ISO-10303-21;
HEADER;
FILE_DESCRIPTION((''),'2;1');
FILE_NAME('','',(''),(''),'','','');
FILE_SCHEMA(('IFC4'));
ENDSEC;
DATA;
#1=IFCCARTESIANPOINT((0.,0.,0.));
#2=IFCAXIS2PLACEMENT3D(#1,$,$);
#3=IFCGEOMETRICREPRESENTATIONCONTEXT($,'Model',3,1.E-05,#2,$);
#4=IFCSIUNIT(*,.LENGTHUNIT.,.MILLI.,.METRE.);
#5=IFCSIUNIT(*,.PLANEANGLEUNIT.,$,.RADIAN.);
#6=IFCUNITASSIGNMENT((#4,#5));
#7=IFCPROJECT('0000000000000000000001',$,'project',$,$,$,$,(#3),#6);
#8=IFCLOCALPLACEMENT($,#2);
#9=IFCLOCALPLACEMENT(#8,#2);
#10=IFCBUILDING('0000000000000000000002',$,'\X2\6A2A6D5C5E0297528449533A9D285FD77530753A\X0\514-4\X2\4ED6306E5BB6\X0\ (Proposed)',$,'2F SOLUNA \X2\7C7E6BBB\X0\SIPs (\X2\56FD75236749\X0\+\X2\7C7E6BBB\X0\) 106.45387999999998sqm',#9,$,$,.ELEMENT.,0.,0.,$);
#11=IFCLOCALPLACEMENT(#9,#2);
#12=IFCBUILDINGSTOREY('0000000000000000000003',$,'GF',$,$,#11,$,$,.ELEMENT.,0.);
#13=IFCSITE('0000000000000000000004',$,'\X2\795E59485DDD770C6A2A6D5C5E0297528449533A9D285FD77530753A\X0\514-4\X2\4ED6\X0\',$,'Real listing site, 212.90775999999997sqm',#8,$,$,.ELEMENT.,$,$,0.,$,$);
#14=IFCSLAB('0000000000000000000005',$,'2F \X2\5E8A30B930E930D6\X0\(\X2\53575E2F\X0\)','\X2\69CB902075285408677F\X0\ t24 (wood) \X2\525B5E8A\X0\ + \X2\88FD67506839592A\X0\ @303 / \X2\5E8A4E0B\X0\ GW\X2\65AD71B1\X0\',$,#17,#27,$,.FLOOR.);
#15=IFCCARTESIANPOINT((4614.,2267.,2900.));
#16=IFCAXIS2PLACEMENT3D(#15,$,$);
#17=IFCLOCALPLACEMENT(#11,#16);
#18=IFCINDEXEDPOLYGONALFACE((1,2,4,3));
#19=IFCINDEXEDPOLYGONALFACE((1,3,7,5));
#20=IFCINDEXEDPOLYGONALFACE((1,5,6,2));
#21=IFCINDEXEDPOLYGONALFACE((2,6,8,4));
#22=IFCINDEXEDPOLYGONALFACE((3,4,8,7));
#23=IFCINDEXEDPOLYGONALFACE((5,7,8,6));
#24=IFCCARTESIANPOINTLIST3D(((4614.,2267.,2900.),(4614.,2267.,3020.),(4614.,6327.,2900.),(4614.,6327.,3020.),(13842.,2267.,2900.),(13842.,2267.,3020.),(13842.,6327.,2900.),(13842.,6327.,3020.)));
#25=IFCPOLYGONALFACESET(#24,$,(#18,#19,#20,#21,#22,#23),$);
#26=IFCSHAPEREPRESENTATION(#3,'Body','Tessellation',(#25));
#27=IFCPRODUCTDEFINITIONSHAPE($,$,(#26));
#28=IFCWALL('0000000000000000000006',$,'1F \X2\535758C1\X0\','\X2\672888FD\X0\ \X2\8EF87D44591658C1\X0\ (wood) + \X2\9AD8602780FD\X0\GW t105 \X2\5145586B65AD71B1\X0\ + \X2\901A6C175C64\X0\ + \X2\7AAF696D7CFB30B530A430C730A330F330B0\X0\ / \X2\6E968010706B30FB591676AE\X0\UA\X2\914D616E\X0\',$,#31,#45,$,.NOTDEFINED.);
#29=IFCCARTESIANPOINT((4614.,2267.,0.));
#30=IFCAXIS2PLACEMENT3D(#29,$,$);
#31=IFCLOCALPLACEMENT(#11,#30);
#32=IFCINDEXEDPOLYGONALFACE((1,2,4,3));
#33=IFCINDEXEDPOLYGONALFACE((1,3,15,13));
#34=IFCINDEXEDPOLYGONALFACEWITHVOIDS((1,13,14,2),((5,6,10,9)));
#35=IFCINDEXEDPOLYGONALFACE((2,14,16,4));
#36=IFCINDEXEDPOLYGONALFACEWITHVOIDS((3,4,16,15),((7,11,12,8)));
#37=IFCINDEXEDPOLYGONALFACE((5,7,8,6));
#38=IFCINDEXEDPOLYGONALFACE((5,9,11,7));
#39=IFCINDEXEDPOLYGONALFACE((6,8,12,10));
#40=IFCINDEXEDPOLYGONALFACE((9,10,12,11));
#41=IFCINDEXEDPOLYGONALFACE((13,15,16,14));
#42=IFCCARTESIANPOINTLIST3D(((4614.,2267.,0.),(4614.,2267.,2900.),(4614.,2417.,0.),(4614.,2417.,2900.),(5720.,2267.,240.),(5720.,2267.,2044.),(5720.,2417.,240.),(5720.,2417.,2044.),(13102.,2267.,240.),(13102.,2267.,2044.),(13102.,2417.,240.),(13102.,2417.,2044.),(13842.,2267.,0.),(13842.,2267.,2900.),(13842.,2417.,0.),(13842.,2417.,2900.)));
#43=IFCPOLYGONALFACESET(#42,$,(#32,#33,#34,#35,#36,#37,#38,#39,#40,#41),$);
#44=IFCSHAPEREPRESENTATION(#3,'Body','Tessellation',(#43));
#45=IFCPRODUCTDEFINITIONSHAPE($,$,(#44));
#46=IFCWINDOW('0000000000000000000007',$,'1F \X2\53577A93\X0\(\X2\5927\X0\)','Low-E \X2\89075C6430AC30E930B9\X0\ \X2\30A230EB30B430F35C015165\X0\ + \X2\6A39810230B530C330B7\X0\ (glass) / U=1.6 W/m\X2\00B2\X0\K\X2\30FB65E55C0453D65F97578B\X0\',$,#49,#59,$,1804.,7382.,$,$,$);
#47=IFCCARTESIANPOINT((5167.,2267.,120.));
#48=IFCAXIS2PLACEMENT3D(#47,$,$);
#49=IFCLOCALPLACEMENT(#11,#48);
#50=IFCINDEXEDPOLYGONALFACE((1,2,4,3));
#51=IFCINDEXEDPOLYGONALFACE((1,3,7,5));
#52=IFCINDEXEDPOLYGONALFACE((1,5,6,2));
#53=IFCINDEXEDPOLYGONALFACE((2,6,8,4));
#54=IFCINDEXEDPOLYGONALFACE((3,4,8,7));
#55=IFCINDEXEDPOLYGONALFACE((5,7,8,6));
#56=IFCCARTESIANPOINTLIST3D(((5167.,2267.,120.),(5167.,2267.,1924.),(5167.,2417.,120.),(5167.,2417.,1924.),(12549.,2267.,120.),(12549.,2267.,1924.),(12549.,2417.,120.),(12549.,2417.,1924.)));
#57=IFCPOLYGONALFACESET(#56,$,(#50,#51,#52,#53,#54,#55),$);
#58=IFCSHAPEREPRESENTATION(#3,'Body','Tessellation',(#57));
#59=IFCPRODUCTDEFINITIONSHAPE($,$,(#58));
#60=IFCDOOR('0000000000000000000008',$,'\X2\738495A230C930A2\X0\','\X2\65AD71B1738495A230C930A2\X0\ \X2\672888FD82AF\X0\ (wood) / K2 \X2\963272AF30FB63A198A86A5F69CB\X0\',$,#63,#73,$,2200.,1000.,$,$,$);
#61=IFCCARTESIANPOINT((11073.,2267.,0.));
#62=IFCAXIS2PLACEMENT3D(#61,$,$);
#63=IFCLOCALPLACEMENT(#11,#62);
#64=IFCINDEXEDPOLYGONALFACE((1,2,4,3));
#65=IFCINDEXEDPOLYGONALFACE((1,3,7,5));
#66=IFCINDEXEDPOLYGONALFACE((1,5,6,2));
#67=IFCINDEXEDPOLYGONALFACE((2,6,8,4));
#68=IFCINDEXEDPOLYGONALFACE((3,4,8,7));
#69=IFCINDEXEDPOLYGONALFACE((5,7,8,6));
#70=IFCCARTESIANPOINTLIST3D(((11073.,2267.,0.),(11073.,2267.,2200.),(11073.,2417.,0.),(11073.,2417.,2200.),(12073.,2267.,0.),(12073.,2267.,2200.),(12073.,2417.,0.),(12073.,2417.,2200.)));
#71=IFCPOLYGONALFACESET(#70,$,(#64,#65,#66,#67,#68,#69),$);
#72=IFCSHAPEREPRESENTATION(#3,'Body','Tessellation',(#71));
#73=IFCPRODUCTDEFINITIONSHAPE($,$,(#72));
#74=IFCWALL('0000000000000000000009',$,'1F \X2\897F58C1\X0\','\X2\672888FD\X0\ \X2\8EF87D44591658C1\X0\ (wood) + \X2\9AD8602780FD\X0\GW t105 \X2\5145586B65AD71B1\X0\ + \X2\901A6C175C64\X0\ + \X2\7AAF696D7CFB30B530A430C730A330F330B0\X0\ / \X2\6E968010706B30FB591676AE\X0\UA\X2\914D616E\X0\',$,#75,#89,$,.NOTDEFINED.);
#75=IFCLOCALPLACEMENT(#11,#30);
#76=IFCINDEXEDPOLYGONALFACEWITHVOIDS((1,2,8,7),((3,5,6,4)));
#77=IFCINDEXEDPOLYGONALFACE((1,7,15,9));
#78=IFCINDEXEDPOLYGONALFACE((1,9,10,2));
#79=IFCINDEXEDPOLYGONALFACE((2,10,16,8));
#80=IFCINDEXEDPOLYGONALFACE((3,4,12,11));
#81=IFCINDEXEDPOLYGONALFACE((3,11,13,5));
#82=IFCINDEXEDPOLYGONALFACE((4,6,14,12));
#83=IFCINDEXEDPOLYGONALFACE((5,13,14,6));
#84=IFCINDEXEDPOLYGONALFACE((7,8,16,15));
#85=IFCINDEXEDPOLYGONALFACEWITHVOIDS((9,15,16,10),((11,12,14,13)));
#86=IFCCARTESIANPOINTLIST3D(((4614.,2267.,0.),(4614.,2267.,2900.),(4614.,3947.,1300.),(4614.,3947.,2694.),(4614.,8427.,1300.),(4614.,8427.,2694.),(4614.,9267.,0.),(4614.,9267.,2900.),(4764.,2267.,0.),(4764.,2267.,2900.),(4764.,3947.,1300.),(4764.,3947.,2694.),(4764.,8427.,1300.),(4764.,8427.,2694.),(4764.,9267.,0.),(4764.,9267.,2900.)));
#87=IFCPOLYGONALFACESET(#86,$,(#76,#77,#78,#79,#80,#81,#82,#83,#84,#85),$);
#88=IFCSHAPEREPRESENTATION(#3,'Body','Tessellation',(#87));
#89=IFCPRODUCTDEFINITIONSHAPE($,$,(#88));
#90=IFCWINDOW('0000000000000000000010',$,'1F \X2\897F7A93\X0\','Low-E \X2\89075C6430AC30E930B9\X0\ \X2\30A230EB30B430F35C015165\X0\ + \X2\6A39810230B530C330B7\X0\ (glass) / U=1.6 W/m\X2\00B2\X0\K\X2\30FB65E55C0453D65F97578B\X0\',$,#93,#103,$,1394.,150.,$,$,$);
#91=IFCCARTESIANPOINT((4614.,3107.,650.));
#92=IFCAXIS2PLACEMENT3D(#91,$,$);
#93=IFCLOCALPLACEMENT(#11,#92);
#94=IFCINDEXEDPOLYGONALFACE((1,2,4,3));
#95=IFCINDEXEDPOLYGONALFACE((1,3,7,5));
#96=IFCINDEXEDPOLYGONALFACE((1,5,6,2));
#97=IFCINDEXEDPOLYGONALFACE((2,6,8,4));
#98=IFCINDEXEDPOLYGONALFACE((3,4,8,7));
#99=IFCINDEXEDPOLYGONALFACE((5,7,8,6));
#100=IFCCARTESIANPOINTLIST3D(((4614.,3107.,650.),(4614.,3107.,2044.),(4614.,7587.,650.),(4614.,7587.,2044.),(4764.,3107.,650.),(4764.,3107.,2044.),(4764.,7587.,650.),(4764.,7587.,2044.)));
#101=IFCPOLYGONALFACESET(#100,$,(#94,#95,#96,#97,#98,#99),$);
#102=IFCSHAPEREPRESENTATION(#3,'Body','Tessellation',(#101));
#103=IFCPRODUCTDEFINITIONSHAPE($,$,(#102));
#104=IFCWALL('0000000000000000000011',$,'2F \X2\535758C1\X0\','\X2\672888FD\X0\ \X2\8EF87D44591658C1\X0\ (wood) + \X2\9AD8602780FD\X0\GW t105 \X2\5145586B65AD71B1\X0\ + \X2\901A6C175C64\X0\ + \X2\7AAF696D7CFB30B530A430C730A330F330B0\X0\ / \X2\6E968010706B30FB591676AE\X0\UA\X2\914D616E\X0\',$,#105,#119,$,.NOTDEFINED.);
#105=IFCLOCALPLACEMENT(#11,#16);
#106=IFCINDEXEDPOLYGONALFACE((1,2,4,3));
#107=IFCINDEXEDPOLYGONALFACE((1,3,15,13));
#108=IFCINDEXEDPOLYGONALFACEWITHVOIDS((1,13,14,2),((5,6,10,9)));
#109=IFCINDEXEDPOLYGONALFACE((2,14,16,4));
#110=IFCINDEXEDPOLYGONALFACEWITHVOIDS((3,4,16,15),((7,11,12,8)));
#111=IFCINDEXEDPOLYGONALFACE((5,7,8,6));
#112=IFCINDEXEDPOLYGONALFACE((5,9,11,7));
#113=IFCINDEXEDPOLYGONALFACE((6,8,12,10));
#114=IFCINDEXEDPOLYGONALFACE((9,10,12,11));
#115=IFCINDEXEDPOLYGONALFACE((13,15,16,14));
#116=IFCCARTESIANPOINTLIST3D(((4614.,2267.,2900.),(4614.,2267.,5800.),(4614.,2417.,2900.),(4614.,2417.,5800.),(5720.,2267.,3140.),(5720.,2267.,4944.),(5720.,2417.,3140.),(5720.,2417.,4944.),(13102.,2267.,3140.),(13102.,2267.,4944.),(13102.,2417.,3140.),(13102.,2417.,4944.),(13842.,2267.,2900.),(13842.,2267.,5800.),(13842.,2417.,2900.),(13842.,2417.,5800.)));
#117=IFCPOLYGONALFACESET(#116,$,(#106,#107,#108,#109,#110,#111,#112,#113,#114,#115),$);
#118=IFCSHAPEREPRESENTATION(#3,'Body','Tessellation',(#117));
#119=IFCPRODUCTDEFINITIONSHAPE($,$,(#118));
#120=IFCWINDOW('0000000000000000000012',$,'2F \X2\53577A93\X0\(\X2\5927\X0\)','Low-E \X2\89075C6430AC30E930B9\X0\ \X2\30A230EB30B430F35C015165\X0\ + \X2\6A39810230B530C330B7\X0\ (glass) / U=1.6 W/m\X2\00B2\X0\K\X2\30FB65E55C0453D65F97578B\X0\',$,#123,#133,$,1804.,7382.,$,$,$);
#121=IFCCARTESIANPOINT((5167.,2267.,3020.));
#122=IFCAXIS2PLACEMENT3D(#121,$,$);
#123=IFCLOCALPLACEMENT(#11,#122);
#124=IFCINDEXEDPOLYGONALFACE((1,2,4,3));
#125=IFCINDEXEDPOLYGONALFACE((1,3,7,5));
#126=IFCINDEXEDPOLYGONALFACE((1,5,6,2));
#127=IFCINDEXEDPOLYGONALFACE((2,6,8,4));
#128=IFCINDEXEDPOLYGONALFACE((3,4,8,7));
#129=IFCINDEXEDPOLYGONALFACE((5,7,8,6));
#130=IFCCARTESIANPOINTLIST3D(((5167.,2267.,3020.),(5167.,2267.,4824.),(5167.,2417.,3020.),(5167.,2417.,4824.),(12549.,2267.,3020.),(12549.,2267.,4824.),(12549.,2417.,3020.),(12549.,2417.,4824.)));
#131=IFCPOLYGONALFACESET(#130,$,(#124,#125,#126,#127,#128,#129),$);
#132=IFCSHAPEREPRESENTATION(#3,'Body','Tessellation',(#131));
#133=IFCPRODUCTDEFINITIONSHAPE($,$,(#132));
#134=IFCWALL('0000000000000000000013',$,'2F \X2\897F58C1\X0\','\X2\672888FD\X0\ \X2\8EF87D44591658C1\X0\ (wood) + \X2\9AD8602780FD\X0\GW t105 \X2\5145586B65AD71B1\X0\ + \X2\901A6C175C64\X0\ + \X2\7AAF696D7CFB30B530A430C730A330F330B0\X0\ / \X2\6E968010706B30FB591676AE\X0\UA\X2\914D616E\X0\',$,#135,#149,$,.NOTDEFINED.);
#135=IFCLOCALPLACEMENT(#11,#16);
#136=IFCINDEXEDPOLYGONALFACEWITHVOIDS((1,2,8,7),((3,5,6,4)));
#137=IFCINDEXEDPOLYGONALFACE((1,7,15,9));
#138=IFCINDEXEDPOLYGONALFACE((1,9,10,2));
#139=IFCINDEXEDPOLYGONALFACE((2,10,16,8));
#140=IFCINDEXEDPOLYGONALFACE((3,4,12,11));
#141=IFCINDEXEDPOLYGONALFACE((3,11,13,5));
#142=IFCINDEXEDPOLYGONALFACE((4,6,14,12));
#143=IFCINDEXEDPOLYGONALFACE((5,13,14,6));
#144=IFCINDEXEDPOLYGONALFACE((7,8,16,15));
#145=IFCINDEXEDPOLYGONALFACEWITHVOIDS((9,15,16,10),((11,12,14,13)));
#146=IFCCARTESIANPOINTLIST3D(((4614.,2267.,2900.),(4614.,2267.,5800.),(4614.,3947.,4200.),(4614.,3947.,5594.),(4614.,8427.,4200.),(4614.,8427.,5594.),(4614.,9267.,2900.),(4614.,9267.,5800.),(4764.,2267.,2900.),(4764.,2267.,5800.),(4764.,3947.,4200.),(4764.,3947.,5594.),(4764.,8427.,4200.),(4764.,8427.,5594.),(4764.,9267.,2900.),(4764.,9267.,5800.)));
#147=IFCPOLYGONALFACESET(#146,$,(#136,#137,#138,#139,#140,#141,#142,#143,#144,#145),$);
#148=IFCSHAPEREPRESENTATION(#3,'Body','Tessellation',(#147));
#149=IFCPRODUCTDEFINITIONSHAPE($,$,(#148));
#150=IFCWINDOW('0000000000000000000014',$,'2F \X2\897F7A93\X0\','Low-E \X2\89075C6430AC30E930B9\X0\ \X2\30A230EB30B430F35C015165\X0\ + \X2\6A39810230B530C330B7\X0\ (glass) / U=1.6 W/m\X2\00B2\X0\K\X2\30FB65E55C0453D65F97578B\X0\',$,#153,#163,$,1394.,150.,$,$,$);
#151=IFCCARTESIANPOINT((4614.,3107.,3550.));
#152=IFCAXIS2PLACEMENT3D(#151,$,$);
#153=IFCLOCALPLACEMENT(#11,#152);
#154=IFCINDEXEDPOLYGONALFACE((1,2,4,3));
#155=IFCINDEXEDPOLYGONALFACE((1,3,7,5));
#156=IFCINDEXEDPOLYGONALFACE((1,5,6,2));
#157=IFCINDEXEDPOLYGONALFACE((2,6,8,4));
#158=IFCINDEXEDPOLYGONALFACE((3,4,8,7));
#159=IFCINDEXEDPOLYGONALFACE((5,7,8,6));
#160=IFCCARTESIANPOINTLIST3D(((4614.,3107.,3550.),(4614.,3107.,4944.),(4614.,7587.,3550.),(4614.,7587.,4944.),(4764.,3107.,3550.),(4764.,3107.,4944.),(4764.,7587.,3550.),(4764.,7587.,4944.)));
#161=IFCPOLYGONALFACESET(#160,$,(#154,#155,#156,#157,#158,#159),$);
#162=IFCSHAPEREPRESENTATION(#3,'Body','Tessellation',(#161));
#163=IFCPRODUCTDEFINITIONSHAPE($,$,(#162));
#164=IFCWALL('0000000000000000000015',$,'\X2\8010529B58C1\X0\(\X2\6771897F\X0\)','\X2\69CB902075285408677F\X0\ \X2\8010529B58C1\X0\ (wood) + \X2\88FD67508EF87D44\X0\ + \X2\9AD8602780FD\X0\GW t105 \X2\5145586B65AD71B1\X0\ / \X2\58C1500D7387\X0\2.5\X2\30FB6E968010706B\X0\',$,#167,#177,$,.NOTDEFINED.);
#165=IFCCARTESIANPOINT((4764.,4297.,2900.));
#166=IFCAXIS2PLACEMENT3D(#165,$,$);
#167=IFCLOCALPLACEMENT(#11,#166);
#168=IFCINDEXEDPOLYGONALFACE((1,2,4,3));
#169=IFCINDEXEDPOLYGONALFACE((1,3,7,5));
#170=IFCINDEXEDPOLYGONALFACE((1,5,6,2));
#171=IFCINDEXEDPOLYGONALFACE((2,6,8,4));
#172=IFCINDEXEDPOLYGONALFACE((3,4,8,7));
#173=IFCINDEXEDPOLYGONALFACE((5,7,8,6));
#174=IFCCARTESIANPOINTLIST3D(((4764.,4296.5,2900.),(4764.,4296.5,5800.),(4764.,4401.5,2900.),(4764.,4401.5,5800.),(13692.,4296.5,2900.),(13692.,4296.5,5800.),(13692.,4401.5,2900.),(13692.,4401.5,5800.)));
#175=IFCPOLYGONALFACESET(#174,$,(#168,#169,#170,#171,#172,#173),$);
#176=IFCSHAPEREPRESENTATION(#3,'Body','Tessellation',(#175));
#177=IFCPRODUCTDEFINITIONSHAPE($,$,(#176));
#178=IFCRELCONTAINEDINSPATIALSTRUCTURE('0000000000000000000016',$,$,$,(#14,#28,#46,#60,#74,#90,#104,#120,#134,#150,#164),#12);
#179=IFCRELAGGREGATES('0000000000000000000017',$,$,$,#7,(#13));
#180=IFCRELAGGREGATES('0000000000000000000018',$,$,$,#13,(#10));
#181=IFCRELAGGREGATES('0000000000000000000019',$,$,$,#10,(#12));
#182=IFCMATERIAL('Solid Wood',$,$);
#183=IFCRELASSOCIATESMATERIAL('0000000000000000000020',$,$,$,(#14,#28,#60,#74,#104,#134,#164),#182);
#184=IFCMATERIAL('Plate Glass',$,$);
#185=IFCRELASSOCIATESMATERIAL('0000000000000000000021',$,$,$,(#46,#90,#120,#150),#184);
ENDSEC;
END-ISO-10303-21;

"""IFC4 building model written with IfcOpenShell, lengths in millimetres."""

from ifc_helpers import new_model, si_unit, frame, frame_2d, origin, place, context, project, spatial, rectangle, extrude, material, element, fill, save


model = new_model("IFC4")

# Units and contexts
model_context = context("Model", 3, precision=1e-05, world=origin())
ifc_project = project(units=[si_unit("LENGTHUNIT", "METRE", prefix="MILLI"), si_unit("PLANEANGLEUNIT", "RADIAN")], contexts=[model_context])

# Site, building, storey
site_placement = place(None, origin())
site = spatial("IfcSite", under=ifc_project, at=site_placement, Name="神奈川県横浜市青葉区鴨志田町514-4他", ObjectType="Real listing site, 212.90775999999997sqm", CompositionType="ELEMENT", RefElevation=0.0)
building_placement = place(site_placement, origin())
building = spatial("IfcBuilding", under=site, at=building_placement, Name="横浜市青葉区鴨志田町514-4他の家 (Proposed)", ObjectType="2F SOLUNA 籾殻SIPs (国産杉+籾殻) 106.45387999999998sqm", CompositionType="ELEMENT", ElevationOfRefHeight=0.0, ElevationOfTerrain=0.0)
storey_placement = place(building_placement, origin())
storey = spatial("IfcBuildingStorey", under=building, at=storey_placement, Name="GF", CompositionType="ELEMENT", Elevation=0.0)

# Slab
ifc_material_1 = material(Name="Solid Wood")
slab_1_placement = place(storey_placement, frame((4614.0, 2267.0, 2900.0)))
element("IfcSlab", 1, at=slab_1_placement, inside=storey, material=ifc_material_1, Name="2F 床スラブ(南帯)", Description="構造用合板 t24 (wood) 剛床 + 製材根太 @303 / 床下 GW断熱", PredefinedType="FLOOR", context=model_context, shape_type="SweptSolid", body=[
    extrude(rectangle(XDim=9228.0, YDim=4060.0, at=frame_2d((4614.0, 2030.0))), frame((4614.0, 2267.0, 2900.0)), (0.0, 0.0, 1.0), 120.0),
])

# Wall, openings, window, door
wall_1_placement = place(storey_placement, frame((4614.0, 2267.0, 0.0)))
wall_1 = element("IfcWall", 2, at=wall_1_placement, inside=storey, material=ifc_material_1, Name="1F 南壁", Description="木製 軸組外壁 (wood) + 高性能GW t105 充填断熱 + 通気層 + 窯業系サイディング / 準耐火・外皮UA配慮", PredefinedType="NOTDEFINED", context=model_context, shape_type="SweptSolid", body=[
    extrude(rectangle(XDim=9228.0, YDim=150.0, at=frame_2d((4614.0, 75.0))), frame((4614.0, 2267.0, 0.0)), (0.0, 0.0, 1.0), 2900.0),
])
opening_1_placement = place(storey_placement, frame((5167.0, 2267.0, 120.0)))
opening_1 = element("IfcOpeningElement", 3, at=opening_1_placement, cuts=wall_1, PredefinedType="NOTDEFINED", context=model_context, shape_type="SweptSolid", body=[
    extrude(rectangle(XDim=7382.0, YDim=150.0, at=frame_2d((3691.0, 75.0))), frame((5167.0, 2267.0, 120.0)), (0.0, 0.0, 1.0), 1804.0),
])
opening_2_placement = place(storey_placement, frame((11073.0, 2267.0, 0.0)))
opening_2 = element("IfcOpeningElement", 4, at=opening_2_placement, cuts=wall_1, PredefinedType="NOTDEFINED", context=model_context, shape_type="SweptSolid", body=[
    extrude(rectangle(XDim=1000.0, YDim=150.0, at=frame_2d((500.0, 75.0))), frame((11073.0, 2267.0, 0.0)), (0.0, 0.0, 1.0), 2200.0),
])
ifc_material_2 = material(Name="Plate Glass")
window_1_placement = place(storey_placement, frame((5167.0, 2267.0, 120.0)))
window_1 = element("IfcWindow", 5, at=window_1_placement, inside=storey, material=ifc_material_2, Name="1F 南窓(大)", Description="Low-E 複層ガラス アルゴン封入 + 樹脂サッシ (glass) / U=1.6 W/m²K・日射取得型", OverallHeight=1804.0, OverallWidth=7382.0, context=model_context, shape_type="SweptSolid", body=[
    extrude(rectangle(XDim=7382.0, YDim=150.0, at=frame_2d((3691.0, 75.0))), frame((5167.0, 2267.0, 120.0)), (0.0, 0.0, 1.0), 1804.0),
])
fill(opening_1, window_1)
door_placement = place(storey_placement, frame((11073.0, 2267.0, 0.0)))
door = element("IfcDoor", 6, at=door_placement, inside=storey, material=ifc_material_1, Name="玄関ドア", Description="断熱玄関ドア 木製芯 (wood) / K2 防犯・採風機構", OverallHeight=2200.0, OverallWidth=1000.0, context=model_context, shape_type="SweptSolid", body=[
    extrude(rectangle(XDim=1000.0, YDim=150.0, at=frame_2d((500.0, 75.0))), frame((11073.0, 2267.0, 0.0)), (0.0, 0.0, 1.0), 2200.0),
])
fill(opening_2, door)

# Wall, opening, window
wall_2_placement = place(storey_placement, frame((4614.0, 2267.0, 0.0)))
wall_2 = element("IfcWall", 7, at=wall_2_placement, inside=storey, material=ifc_material_1, Name="1F 西壁", Description="木製 軸組外壁 (wood) + 高性能GW t105 充填断熱 + 通気層 + 窯業系サイディング / 準耐火・外皮UA配慮", PredefinedType="NOTDEFINED", context=model_context, shape_type="SweptSolid", body=[
    extrude(rectangle(XDim=150.0, YDim=7000.0, at=frame_2d((75.0, 3500.0))), frame((4614.0, 2267.0, 0.0)), (0.0, 0.0, 1.0), 2900.0),
])
opening_3_placement = place(storey_placement, frame((4614.0, 3107.0, 650.0)))
opening_3 = element("IfcOpeningElement", 8, at=opening_3_placement, cuts=wall_2, PredefinedType="NOTDEFINED", context=model_context, shape_type="SweptSolid", body=[
    extrude(rectangle(XDim=150.0, YDim=4480.0, at=frame_2d((75.0, 2240.0))), frame((4614.0, 3107.0, 650.0)), (0.0, 0.0, 1.0), 1394.0),
])
window_2_placement = place(storey_placement, frame((4614.0, 3107.0, 650.0)))
window_2 = element("IfcWindow", 9, at=window_2_placement, inside=storey, material=ifc_material_2, Name="1F 西窓", Description="Low-E 複層ガラス アルゴン封入 + 樹脂サッシ (glass) / U=1.6 W/m²K・日射取得型", OverallHeight=1394.0, OverallWidth=150.0, context=model_context, shape_type="SweptSolid", body=[
    extrude(rectangle(XDim=150.0, YDim=4480.0, at=frame_2d((75.0, 2240.0))), frame((4614.0, 3107.0, 650.0)), (0.0, 0.0, 1.0), 1394.0),
])
fill(opening_3, window_2)

# Walls, openings, windows
wall_3_placement = place(storey_placement, frame((4614.0, 2267.0, 2900.0)))
wall_3 = element("IfcWall", 10, at=wall_3_placement, inside=storey, material=ifc_material_1, Name="2F 南壁", Description="木製 軸組外壁 (wood) + 高性能GW t105 充填断熱 + 通気層 + 窯業系サイディング / 準耐火・外皮UA配慮", PredefinedType="NOTDEFINED", context=model_context, shape_type="SweptSolid", body=[
    extrude(rectangle(XDim=9228.0, YDim=150.0, at=frame_2d((4614.0, 75.0))), frame((4614.0, 2267.0, 2900.0)), (0.0, 0.0, 1.0), 2900.0),
])
opening_4_placement = place(storey_placement, frame((5167.0, 2267.0, 3020.0)))
opening_4 = element("IfcOpeningElement", 11, at=opening_4_placement, cuts=wall_3, PredefinedType="NOTDEFINED", context=model_context, shape_type="SweptSolid", body=[
    extrude(rectangle(XDim=7382.0, YDim=150.0, at=frame_2d((3691.0, 75.0))), frame((5167.0, 2267.0, 3020.0)), (0.0, 0.0, 1.0), 1804.0),
])
window_3_placement = place(storey_placement, frame((5167.0, 2267.0, 3020.0)))
window_3 = element("IfcWindow", 12, at=window_3_placement, inside=storey, material=ifc_material_2, Name="2F 南窓(大)", Description="Low-E 複層ガラス アルゴン封入 + 樹脂サッシ (glass) / U=1.6 W/m²K・日射取得型", OverallHeight=1804.0, OverallWidth=7382.0, context=model_context, shape_type="SweptSolid", body=[
    extrude(rectangle(XDim=7382.0, YDim=150.0, at=frame_2d((3691.0, 75.0))), frame((5167.0, 2267.0, 3020.0)), (0.0, 0.0, 1.0), 1804.0),
])
fill(opening_4, window_3)
wall_4_placement = place(storey_placement, frame((4614.0, 2267.0, 2900.0)))
wall_4 = element("IfcWall", 13, at=wall_4_placement, inside=storey, material=ifc_material_1, Name="2F 西壁", Description="木製 軸組外壁 (wood) + 高性能GW t105 充填断熱 + 通気層 + 窯業系サイディング / 準耐火・外皮UA配慮", PredefinedType="NOTDEFINED", context=model_context, shape_type="SweptSolid", body=[
    extrude(rectangle(XDim=150.0, YDim=7000.0, at=frame_2d((75.0, 3500.0))), frame((4614.0, 2267.0, 2900.0)), (0.0, 0.0, 1.0), 2900.0),
])
opening_5_placement = place(storey_placement, frame((4614.0, 3107.0, 3550.0)))
opening_5 = element("IfcOpeningElement", 14, at=opening_5_placement, cuts=wall_4, PredefinedType="NOTDEFINED", context=model_context, shape_type="SweptSolid", body=[
    extrude(rectangle(XDim=150.0, YDim=4480.0, at=frame_2d((75.0, 2240.0))), frame((4614.0, 3107.0, 3550.0)), (0.0, 0.0, 1.0), 1394.0),
])
window_4_placement = place(storey_placement, frame((4614.0, 3107.0, 3550.0)))
window_4 = element("IfcWindow", 15, at=window_4_placement, inside=storey, material=ifc_material_2, Name="2F 西窓", Description="Low-E 複層ガラス アルゴン封入 + 樹脂サッシ (glass) / U=1.6 W/m²K・日射取得型", OverallHeight=1394.0, OverallWidth=150.0, context=model_context, shape_type="SweptSolid", body=[
    extrude(rectangle(XDim=150.0, YDim=4480.0, at=frame_2d((75.0, 2240.0))), frame((4614.0, 3107.0, 3550.0)), (0.0, 0.0, 1.0), 1394.0),
])
fill(opening_5, window_4)

# Wall
wall_5_placement = place(storey_placement, frame((4764.0, 4297.0, 2900.0)))
element("IfcWall", 16, at=wall_5_placement, inside=storey, material=ifc_material_1, Name="耐力壁(東西)", Description="構造用合板 耐力壁 (wood) + 製材軸組 + 高性能GW t105 充填断熱 / 壁倍率2.5・準耐火", PredefinedType="NOTDEFINED", context=model_context, shape_type="SweptSolid", body=[
    extrude(rectangle(XDim=8928.0, YDim=105.0, at=frame_2d((4464.0, 52.0))), frame((4764.0, 4297.0, 2900.0)), (0.0, 0.0, 1.0), 2900.0),
])

save(model, "model.ifc")
